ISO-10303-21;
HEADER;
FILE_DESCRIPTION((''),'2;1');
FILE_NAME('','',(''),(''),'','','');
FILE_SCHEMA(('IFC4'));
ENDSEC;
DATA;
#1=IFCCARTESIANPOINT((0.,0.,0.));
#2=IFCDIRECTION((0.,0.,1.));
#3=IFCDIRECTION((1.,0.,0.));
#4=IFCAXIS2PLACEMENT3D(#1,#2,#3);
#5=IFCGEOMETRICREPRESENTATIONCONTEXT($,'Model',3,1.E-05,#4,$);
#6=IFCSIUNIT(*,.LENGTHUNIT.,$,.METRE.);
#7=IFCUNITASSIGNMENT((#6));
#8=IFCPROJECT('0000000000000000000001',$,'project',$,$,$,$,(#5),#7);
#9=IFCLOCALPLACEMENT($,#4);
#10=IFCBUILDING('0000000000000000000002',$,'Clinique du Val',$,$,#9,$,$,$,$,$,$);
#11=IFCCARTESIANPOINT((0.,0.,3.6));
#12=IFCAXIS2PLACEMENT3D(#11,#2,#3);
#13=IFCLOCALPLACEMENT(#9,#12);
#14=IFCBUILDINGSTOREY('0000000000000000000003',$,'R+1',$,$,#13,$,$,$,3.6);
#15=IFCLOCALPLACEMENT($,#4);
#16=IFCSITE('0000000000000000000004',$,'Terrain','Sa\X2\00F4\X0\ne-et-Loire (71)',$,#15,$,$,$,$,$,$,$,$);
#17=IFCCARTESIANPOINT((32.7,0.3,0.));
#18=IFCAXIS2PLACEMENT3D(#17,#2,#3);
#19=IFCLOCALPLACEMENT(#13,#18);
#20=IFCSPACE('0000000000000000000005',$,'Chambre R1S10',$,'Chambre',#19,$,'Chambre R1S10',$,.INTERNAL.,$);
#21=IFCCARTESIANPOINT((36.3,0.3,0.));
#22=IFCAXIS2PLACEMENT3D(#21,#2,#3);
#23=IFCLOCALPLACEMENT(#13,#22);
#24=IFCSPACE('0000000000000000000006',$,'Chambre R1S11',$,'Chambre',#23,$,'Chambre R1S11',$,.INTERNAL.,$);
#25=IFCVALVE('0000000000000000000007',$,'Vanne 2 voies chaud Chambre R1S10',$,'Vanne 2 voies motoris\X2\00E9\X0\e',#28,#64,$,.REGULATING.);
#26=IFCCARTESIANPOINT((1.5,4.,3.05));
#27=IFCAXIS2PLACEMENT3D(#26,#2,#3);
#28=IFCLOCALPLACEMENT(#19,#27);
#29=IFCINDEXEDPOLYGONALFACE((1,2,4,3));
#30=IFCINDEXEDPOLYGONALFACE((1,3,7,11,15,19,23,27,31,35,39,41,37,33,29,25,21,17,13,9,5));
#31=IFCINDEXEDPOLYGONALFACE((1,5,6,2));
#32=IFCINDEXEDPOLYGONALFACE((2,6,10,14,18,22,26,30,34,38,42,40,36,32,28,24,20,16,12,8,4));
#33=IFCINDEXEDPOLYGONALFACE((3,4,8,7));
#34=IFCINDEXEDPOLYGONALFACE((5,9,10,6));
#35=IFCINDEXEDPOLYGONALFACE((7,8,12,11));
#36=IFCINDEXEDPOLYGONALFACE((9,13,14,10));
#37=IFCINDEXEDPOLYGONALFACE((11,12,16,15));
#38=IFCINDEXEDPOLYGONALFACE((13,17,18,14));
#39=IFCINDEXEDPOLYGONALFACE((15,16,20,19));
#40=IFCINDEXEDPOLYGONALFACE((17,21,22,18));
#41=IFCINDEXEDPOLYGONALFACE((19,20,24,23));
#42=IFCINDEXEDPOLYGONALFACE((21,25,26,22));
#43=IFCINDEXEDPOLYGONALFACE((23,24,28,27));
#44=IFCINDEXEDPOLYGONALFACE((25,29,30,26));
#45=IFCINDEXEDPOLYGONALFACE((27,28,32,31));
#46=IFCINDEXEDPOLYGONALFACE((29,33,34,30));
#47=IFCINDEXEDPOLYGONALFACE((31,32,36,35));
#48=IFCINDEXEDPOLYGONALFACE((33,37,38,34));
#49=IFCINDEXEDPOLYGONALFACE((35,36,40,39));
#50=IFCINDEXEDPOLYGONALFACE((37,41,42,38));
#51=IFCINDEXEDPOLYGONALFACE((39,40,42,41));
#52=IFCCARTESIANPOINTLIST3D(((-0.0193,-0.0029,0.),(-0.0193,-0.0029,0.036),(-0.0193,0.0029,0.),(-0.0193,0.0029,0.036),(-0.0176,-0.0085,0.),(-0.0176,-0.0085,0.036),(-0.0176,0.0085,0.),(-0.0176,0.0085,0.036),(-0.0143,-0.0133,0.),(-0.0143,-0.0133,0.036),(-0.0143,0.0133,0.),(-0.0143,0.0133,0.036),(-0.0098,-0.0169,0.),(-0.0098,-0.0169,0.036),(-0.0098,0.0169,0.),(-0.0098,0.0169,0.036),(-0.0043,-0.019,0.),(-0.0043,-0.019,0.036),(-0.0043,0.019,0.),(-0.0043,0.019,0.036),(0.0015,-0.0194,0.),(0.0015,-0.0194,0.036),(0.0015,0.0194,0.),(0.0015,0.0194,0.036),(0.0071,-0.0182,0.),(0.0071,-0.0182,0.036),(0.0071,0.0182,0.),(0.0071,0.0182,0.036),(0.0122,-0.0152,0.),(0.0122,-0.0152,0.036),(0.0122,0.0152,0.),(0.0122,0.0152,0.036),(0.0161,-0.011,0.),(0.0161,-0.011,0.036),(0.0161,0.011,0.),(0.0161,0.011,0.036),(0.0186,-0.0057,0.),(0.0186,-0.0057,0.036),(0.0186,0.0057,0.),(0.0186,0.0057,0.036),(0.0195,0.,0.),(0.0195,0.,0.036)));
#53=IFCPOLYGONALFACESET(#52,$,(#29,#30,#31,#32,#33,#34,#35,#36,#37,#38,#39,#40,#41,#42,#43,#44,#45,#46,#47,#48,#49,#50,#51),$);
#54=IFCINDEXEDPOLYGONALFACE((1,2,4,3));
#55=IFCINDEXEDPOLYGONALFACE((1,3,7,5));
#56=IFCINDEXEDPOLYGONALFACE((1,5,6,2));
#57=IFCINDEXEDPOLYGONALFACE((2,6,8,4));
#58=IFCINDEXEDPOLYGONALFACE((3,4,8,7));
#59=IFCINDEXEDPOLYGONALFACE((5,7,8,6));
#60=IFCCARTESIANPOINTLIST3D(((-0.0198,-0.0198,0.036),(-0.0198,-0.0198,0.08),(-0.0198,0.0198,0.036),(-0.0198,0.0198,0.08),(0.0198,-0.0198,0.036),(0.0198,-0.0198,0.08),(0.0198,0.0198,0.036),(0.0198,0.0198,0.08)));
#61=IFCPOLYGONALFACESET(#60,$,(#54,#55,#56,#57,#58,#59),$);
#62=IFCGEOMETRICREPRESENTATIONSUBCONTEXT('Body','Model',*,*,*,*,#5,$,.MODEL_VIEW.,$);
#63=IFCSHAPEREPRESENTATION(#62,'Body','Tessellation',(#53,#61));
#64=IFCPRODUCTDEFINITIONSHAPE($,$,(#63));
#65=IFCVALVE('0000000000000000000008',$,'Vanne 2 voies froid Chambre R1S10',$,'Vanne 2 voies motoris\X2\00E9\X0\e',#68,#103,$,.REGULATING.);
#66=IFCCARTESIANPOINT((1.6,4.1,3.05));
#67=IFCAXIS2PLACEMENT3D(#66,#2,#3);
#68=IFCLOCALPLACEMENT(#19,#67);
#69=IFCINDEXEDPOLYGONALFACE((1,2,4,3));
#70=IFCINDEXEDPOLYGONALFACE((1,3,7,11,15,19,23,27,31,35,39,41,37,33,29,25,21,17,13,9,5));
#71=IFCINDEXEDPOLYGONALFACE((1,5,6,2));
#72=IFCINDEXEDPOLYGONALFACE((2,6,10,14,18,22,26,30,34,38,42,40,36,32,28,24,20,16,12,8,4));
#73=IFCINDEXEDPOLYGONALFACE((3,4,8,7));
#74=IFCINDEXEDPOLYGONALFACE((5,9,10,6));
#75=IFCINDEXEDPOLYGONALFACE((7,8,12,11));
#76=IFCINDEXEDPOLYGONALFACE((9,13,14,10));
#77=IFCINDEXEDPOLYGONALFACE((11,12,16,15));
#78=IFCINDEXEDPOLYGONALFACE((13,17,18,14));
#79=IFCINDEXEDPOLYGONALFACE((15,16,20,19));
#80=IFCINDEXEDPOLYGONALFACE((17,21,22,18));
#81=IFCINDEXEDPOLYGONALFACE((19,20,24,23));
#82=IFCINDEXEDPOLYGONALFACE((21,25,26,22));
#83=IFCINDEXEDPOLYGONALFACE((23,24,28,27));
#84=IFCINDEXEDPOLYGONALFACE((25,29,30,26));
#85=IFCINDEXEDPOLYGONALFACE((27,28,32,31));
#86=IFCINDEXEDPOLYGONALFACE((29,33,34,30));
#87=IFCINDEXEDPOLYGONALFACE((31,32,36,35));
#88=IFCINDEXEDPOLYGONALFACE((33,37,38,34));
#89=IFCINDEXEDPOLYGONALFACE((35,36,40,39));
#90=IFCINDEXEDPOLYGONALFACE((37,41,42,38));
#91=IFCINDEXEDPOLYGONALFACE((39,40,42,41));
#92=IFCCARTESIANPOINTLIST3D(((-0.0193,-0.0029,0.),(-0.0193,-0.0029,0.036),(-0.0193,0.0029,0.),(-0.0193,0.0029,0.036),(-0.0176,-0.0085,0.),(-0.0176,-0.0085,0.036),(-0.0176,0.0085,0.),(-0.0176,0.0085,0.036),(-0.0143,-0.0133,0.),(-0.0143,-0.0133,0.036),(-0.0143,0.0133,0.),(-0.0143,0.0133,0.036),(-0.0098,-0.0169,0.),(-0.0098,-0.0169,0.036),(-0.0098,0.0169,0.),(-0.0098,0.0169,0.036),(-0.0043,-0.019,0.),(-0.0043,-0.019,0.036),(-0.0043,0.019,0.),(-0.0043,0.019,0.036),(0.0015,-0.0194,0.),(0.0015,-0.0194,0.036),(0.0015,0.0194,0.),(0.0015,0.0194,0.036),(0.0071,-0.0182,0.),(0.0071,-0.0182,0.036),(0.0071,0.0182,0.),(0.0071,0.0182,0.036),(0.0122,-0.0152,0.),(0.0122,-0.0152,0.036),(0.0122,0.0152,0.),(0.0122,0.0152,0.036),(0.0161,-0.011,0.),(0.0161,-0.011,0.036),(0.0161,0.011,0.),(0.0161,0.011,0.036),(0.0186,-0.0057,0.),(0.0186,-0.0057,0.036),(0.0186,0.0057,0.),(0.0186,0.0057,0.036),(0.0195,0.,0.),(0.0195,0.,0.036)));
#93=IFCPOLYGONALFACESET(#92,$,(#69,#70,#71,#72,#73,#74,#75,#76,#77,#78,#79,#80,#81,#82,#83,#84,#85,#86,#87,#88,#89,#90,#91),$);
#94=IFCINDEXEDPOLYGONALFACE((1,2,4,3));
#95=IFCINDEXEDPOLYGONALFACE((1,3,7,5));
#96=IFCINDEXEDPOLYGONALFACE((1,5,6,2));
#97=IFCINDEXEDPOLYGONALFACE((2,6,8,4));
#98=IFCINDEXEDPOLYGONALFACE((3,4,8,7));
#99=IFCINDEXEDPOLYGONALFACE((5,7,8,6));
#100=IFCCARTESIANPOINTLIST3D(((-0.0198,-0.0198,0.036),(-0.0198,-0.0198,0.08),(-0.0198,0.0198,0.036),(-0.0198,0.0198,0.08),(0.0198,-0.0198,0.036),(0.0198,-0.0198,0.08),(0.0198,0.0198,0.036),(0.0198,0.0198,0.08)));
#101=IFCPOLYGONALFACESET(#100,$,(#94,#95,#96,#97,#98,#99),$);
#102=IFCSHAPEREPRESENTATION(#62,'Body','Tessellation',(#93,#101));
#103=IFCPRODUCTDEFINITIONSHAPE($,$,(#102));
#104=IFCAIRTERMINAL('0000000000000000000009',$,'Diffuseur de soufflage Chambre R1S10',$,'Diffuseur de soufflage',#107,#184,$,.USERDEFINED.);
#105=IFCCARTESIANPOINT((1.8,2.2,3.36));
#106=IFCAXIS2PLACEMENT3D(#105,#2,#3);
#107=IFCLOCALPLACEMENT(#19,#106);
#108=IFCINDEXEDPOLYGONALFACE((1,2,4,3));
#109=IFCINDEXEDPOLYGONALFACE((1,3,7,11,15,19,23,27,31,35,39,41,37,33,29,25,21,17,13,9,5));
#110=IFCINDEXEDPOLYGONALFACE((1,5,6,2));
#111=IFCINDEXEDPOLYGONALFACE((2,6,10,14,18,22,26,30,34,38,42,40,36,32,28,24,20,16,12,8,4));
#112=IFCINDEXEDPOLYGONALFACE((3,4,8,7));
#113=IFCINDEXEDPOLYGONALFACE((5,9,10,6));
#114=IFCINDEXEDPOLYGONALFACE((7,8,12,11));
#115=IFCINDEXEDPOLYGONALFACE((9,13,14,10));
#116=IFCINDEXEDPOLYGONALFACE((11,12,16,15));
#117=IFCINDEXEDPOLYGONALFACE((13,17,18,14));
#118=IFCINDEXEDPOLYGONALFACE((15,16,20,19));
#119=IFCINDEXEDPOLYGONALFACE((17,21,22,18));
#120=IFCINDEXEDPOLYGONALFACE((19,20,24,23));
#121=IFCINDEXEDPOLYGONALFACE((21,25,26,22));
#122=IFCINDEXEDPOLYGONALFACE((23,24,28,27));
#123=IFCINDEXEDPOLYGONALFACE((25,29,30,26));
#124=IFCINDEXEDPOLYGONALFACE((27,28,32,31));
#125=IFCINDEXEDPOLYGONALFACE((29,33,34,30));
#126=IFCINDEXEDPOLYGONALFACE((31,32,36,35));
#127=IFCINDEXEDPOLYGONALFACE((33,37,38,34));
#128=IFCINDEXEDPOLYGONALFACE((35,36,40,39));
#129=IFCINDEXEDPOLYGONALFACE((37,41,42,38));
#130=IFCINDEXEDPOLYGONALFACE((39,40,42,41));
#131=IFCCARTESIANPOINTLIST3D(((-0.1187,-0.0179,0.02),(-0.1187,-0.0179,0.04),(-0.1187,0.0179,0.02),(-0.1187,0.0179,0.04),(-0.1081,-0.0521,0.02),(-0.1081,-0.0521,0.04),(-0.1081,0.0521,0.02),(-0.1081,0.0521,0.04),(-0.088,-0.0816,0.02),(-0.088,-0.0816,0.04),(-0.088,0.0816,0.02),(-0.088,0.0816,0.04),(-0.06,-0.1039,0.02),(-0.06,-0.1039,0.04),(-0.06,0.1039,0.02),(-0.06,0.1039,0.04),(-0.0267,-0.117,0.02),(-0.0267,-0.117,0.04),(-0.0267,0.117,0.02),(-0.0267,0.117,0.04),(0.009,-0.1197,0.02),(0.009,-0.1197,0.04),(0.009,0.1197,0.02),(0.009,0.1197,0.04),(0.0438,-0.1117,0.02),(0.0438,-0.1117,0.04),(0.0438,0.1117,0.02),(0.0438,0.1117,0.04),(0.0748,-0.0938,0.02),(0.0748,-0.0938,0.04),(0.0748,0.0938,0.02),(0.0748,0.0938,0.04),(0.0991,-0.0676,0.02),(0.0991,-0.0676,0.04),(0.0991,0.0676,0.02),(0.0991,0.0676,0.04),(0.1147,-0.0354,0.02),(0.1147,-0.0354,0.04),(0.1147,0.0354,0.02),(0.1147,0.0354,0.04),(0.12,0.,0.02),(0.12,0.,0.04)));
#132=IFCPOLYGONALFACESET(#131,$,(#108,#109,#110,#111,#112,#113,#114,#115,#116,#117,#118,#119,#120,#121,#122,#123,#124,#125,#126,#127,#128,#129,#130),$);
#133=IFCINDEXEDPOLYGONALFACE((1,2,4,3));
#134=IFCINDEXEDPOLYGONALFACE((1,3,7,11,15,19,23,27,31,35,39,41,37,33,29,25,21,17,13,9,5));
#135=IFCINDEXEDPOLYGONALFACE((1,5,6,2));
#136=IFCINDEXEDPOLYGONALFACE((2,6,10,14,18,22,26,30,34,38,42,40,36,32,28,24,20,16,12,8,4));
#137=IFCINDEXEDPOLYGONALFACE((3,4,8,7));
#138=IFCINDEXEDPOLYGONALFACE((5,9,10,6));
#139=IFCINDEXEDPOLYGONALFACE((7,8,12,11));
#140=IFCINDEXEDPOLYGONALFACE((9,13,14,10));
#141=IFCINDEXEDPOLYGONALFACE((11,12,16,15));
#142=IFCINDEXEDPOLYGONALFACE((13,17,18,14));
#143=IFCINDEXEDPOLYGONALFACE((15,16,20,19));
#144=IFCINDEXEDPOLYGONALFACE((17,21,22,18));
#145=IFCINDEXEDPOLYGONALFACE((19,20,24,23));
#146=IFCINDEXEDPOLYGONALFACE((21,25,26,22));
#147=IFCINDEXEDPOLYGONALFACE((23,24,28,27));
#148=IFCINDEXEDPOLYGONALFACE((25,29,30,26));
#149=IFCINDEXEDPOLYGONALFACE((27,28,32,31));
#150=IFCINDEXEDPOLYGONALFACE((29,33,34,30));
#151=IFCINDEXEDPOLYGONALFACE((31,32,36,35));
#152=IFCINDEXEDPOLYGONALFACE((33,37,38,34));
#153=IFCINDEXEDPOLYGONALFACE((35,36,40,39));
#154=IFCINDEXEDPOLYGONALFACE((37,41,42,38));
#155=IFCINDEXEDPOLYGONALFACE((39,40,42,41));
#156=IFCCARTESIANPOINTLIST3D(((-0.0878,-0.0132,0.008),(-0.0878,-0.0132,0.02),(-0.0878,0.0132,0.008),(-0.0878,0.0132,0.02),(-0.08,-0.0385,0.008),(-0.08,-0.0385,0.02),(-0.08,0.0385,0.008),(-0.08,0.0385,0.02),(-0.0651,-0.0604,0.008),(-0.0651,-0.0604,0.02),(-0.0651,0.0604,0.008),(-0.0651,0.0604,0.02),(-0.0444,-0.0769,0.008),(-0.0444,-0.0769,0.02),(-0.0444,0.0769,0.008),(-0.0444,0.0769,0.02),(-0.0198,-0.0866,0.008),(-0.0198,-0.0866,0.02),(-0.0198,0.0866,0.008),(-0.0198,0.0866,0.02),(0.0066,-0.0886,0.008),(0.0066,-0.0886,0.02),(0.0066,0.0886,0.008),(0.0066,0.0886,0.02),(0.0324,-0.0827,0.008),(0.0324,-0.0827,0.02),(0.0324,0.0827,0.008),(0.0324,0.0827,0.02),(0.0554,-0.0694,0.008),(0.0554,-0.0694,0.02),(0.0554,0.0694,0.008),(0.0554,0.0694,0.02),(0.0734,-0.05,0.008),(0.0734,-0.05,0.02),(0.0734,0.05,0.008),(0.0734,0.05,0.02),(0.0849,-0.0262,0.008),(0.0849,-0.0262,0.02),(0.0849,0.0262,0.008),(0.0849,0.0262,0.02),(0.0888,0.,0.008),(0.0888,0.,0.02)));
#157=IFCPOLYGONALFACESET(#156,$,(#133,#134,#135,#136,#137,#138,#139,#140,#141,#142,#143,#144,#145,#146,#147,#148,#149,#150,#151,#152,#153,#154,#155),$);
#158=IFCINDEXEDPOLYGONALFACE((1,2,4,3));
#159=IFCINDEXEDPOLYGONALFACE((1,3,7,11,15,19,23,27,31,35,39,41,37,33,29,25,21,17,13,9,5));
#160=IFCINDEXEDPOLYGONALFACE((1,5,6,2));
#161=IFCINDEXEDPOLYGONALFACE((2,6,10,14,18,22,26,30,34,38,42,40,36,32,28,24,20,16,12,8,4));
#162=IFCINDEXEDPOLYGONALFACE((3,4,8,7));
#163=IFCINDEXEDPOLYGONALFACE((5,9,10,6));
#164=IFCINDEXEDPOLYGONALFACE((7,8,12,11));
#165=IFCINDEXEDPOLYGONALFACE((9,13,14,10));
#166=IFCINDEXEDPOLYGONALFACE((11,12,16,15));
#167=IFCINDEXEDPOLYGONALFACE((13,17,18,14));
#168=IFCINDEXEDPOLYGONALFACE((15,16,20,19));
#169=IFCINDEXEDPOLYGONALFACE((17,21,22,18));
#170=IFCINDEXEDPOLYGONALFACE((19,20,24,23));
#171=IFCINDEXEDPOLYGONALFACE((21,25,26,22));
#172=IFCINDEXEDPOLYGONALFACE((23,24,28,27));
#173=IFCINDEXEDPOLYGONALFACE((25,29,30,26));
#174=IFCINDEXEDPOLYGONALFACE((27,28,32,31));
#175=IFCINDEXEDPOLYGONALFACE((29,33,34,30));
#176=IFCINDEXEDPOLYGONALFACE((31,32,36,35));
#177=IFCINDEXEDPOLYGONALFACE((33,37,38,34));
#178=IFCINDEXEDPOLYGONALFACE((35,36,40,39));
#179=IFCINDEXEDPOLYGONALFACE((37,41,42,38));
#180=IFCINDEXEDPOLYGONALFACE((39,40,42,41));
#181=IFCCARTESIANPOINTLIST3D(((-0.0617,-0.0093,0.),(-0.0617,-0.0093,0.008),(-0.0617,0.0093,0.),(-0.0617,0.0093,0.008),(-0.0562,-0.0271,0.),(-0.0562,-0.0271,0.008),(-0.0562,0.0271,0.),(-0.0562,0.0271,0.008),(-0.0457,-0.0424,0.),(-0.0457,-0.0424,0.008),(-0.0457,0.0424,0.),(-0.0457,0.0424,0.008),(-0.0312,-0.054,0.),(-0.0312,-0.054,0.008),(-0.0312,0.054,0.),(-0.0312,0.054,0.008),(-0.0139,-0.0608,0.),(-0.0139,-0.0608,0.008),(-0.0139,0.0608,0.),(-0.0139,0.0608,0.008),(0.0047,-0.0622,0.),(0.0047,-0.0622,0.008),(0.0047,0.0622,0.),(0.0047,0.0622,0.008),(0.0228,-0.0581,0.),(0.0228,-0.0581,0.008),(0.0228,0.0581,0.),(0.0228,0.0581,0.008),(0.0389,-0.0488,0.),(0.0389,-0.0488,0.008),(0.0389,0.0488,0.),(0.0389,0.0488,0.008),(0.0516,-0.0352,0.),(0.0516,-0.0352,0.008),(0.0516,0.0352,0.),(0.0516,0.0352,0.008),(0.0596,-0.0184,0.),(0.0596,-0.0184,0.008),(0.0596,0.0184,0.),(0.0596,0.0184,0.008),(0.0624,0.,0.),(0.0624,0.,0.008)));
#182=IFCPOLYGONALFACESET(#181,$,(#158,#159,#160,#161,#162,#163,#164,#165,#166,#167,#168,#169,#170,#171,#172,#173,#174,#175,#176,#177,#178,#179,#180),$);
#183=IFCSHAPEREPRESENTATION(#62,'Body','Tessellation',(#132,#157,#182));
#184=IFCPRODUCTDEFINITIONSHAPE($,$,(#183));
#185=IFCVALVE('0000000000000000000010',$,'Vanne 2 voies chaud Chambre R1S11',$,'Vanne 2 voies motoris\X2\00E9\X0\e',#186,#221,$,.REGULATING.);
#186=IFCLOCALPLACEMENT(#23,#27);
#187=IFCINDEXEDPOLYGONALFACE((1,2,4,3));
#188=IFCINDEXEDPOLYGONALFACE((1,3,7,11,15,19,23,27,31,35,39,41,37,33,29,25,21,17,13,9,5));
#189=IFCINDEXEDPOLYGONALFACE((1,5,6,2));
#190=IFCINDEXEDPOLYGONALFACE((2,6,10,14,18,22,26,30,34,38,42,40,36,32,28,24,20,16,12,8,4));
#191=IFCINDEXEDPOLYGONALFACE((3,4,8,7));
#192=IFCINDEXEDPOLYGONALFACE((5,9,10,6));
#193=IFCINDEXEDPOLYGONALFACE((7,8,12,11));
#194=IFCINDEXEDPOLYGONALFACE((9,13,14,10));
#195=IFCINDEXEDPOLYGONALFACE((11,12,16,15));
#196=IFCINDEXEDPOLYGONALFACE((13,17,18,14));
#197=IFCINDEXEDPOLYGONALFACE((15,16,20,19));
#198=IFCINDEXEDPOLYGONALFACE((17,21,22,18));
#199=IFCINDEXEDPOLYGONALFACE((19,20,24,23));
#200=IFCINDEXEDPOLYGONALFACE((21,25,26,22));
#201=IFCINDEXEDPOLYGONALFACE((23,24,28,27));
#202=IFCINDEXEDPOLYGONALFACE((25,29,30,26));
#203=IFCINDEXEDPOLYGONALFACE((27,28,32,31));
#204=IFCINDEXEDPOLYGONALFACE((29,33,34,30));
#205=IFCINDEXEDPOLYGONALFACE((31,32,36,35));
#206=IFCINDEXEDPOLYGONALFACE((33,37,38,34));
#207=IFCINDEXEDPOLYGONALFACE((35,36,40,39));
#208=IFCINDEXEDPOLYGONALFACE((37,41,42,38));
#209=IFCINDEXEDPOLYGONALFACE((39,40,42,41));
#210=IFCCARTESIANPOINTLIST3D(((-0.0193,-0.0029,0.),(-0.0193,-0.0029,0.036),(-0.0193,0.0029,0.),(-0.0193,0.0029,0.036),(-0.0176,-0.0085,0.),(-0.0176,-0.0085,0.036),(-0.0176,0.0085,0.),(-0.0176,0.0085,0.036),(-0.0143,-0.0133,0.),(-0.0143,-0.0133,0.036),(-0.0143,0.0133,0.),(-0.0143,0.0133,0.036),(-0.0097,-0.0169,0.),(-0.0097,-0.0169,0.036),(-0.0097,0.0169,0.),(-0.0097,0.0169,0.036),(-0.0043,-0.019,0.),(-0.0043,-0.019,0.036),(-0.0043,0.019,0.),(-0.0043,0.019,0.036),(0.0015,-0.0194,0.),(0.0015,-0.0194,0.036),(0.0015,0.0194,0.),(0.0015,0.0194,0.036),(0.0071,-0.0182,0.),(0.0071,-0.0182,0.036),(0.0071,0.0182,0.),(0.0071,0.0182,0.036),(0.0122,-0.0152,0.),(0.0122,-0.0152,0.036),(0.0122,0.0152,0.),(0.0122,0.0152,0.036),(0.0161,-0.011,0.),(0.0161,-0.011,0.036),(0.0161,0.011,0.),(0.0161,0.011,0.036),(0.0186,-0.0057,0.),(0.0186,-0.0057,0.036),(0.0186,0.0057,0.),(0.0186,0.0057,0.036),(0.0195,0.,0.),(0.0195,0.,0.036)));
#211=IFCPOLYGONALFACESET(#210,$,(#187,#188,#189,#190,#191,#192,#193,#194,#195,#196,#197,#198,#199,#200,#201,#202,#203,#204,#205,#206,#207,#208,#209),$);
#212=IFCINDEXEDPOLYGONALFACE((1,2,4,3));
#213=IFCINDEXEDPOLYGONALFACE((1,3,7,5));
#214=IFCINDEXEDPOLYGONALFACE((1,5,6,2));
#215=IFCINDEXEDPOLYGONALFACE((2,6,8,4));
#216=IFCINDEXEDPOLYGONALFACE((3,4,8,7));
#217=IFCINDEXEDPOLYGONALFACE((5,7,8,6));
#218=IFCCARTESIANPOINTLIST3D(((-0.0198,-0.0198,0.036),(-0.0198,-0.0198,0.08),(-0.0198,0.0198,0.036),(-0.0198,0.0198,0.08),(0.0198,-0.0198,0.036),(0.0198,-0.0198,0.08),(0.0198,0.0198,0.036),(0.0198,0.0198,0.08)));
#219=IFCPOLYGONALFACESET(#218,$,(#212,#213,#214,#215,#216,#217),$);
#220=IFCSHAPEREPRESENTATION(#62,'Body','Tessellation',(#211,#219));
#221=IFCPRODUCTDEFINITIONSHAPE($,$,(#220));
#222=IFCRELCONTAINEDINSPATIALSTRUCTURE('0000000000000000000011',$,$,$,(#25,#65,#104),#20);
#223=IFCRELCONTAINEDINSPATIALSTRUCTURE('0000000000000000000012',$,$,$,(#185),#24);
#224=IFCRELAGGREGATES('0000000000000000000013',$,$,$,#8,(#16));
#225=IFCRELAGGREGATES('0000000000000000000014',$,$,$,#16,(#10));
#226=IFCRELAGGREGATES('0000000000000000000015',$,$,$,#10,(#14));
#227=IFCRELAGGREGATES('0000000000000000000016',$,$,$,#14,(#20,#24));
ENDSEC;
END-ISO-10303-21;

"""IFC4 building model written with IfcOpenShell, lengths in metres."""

from ifc_helpers import new_model, si_unit, frame, frame_2d, origin_with_axes, place, context, subcontext, project, spatial, rectangle, circle, extrude, element, save


model = new_model("IFC4")

# Units and contexts
model_context = context("Model", 3, precision=1e-05, world=origin_with_axes())
body_context = subcontext(model_context, "Body", "Model", "MODEL_VIEW")
ifc_project = project(units=[si_unit("LENGTHUNIT", "METRE")], contexts=[model_context])

# Site, building, storey
site_placement = place(None, origin_with_axes())
site = spatial("IfcSite", under=ifc_project, at=site_placement, Name="Terrain", Description="Saône-et-Loire (71)")
building_placement = place(None, origin_with_axes())
building = spatial("IfcBuilding", under=site, at=building_placement, Name="Clinique du Val")
storey_placement = place(building_placement, frame((0.0, 0.0, 3.6), z_axis=(0.0, 0.0, 1.0), x_axis=(1.0, 0.0, 0.0)))
storey = spatial("IfcBuildingStorey", under=building, at=storey_placement, Name="R+1", Elevation=3.6)

# Shared definitions
space_1_placement = place(storey_placement, frame((32.7, 0.3, 0.0), z_axis=(0.0, 0.0, 1.0), x_axis=(1.0, 0.0, 0.0)))
space_1 = spatial("IfcSpace", under=storey, at=space_1_placement, Name="Chambre R1S10", ObjectType="Chambre", LongName="Chambre R1S10", PredefinedType="INTERNAL")

# Valves
for number, where, z_axis, x_axis, name in (
    (1, (1.5, 4.0, 3.05), (0.0, 0.0, 1.0), (1.0, 0.0, 0.0), "Vanne 2 voies chaud Chambre R1S10"),
    (2, (1.6, 4.1, 3.05), (0.0, 0.0, 1.0), (1.0, 0.0, 0.0), "Vanne 2 voies froid Chambre R1S10"),
):
    element("IfcValve", number, at=place(space_1_placement, frame(where, z_axis=z_axis, x_axis=x_axis)), inside=space_1, Name=name, ObjectType="Vanne 2 voies motorisée", PredefinedType="REGULATING", context=body_context, shape_type="SweptSolid", body=[
        extrude(circle(Radius=0.0195), origin_with_axes(), (0.0, 0.0, 1.0), 0.036),
        extrude(rectangle(XDim=0.0396, YDim=0.0396, at=frame_2d((0.0198, 0.0198))), frame((-0.0198, -0.0198, 0.036), z_axis=(0.0, 0.0, 1.0), x_axis=(1.0, 0.0, 0.0)), (0.0, 0.0, 1.0), 0.044),
    ])

# Air terminal
air_terminal_1_placement = place(space_1_placement, frame((1.8, 2.2, 3.36), z_axis=(0.0, 0.0, 1.0), x_axis=(1.0, 0.0, 0.0)))
element("IfcAirTerminal", 3, at=air_terminal_1_placement, inside=space_1, Name="Diffuseur de soufflage Chambre R1S10", ObjectType="Diffuseur de soufflage", PredefinedType="USERDEFINED", context=body_context, shape_type="SweptSolid", body=[
    extrude(circle(Radius=0.12), frame((0.0, 0.0, 0.02), z_axis=(0.0, 0.0, 1.0), x_axis=(1.0, 0.0, 0.0)), (0.0, 0.0, 1.0), 0.02),
    extrude(circle(Radius=0.0888), frame((0.0, 0.0, 0.008), z_axis=(0.0, 0.0, 1.0), x_axis=(1.0, 0.0, 0.0)), (0.0, 0.0, 1.0), 0.012),
    extrude(circle(Radius=0.0624), origin_with_axes(), (0.0, 0.0, 1.0), 0.008),
])

# Shared definitions
space_2_placement = place(storey_placement, frame((36.3, 0.3, 0.0), z_axis=(0.0, 0.0, 1.0), x_axis=(1.0, 0.0, 0.0)))
space_2 = spatial("IfcSpace", under=storey, at=space_2_placement, Name="Chambre R1S11", ObjectType="Chambre", LongName="Chambre R1S11", PredefinedType="INTERNAL")

# Valve
for number, where, z_axis, x_axis, name in (
    (4, (1.5, 4.0, 3.05), (0.0, 0.0, 1.0), (1.0, 0.0, 0.0), "Vanne 2 voies chaud Chambre R1S11"),
):
    element("IfcValve", number, at=place(space_2_placement, frame(where, z_axis=z_axis, x_axis=x_axis)), inside=space_2, Name=name, ObjectType="Vanne 2 voies motorisée", PredefinedType="REGULATING", context=body_context, shape_type="SweptSolid", body=[
        extrude(circle(Radius=0.0195), origin_with_axes(), (0.0, 0.0, 1.0), 0.036),
        extrude(rectangle(XDim=0.0396, YDim=0.0396, at=frame_2d((0.0198, 0.0198))), frame((-0.0198, -0.0198, 0.036), z_axis=(0.0, 0.0, 1.0), x_axis=(1.0, 0.0, 0.0)), (0.0, 0.0, 1.0), 0.044),
    ])

save(model, "model.ifc")
